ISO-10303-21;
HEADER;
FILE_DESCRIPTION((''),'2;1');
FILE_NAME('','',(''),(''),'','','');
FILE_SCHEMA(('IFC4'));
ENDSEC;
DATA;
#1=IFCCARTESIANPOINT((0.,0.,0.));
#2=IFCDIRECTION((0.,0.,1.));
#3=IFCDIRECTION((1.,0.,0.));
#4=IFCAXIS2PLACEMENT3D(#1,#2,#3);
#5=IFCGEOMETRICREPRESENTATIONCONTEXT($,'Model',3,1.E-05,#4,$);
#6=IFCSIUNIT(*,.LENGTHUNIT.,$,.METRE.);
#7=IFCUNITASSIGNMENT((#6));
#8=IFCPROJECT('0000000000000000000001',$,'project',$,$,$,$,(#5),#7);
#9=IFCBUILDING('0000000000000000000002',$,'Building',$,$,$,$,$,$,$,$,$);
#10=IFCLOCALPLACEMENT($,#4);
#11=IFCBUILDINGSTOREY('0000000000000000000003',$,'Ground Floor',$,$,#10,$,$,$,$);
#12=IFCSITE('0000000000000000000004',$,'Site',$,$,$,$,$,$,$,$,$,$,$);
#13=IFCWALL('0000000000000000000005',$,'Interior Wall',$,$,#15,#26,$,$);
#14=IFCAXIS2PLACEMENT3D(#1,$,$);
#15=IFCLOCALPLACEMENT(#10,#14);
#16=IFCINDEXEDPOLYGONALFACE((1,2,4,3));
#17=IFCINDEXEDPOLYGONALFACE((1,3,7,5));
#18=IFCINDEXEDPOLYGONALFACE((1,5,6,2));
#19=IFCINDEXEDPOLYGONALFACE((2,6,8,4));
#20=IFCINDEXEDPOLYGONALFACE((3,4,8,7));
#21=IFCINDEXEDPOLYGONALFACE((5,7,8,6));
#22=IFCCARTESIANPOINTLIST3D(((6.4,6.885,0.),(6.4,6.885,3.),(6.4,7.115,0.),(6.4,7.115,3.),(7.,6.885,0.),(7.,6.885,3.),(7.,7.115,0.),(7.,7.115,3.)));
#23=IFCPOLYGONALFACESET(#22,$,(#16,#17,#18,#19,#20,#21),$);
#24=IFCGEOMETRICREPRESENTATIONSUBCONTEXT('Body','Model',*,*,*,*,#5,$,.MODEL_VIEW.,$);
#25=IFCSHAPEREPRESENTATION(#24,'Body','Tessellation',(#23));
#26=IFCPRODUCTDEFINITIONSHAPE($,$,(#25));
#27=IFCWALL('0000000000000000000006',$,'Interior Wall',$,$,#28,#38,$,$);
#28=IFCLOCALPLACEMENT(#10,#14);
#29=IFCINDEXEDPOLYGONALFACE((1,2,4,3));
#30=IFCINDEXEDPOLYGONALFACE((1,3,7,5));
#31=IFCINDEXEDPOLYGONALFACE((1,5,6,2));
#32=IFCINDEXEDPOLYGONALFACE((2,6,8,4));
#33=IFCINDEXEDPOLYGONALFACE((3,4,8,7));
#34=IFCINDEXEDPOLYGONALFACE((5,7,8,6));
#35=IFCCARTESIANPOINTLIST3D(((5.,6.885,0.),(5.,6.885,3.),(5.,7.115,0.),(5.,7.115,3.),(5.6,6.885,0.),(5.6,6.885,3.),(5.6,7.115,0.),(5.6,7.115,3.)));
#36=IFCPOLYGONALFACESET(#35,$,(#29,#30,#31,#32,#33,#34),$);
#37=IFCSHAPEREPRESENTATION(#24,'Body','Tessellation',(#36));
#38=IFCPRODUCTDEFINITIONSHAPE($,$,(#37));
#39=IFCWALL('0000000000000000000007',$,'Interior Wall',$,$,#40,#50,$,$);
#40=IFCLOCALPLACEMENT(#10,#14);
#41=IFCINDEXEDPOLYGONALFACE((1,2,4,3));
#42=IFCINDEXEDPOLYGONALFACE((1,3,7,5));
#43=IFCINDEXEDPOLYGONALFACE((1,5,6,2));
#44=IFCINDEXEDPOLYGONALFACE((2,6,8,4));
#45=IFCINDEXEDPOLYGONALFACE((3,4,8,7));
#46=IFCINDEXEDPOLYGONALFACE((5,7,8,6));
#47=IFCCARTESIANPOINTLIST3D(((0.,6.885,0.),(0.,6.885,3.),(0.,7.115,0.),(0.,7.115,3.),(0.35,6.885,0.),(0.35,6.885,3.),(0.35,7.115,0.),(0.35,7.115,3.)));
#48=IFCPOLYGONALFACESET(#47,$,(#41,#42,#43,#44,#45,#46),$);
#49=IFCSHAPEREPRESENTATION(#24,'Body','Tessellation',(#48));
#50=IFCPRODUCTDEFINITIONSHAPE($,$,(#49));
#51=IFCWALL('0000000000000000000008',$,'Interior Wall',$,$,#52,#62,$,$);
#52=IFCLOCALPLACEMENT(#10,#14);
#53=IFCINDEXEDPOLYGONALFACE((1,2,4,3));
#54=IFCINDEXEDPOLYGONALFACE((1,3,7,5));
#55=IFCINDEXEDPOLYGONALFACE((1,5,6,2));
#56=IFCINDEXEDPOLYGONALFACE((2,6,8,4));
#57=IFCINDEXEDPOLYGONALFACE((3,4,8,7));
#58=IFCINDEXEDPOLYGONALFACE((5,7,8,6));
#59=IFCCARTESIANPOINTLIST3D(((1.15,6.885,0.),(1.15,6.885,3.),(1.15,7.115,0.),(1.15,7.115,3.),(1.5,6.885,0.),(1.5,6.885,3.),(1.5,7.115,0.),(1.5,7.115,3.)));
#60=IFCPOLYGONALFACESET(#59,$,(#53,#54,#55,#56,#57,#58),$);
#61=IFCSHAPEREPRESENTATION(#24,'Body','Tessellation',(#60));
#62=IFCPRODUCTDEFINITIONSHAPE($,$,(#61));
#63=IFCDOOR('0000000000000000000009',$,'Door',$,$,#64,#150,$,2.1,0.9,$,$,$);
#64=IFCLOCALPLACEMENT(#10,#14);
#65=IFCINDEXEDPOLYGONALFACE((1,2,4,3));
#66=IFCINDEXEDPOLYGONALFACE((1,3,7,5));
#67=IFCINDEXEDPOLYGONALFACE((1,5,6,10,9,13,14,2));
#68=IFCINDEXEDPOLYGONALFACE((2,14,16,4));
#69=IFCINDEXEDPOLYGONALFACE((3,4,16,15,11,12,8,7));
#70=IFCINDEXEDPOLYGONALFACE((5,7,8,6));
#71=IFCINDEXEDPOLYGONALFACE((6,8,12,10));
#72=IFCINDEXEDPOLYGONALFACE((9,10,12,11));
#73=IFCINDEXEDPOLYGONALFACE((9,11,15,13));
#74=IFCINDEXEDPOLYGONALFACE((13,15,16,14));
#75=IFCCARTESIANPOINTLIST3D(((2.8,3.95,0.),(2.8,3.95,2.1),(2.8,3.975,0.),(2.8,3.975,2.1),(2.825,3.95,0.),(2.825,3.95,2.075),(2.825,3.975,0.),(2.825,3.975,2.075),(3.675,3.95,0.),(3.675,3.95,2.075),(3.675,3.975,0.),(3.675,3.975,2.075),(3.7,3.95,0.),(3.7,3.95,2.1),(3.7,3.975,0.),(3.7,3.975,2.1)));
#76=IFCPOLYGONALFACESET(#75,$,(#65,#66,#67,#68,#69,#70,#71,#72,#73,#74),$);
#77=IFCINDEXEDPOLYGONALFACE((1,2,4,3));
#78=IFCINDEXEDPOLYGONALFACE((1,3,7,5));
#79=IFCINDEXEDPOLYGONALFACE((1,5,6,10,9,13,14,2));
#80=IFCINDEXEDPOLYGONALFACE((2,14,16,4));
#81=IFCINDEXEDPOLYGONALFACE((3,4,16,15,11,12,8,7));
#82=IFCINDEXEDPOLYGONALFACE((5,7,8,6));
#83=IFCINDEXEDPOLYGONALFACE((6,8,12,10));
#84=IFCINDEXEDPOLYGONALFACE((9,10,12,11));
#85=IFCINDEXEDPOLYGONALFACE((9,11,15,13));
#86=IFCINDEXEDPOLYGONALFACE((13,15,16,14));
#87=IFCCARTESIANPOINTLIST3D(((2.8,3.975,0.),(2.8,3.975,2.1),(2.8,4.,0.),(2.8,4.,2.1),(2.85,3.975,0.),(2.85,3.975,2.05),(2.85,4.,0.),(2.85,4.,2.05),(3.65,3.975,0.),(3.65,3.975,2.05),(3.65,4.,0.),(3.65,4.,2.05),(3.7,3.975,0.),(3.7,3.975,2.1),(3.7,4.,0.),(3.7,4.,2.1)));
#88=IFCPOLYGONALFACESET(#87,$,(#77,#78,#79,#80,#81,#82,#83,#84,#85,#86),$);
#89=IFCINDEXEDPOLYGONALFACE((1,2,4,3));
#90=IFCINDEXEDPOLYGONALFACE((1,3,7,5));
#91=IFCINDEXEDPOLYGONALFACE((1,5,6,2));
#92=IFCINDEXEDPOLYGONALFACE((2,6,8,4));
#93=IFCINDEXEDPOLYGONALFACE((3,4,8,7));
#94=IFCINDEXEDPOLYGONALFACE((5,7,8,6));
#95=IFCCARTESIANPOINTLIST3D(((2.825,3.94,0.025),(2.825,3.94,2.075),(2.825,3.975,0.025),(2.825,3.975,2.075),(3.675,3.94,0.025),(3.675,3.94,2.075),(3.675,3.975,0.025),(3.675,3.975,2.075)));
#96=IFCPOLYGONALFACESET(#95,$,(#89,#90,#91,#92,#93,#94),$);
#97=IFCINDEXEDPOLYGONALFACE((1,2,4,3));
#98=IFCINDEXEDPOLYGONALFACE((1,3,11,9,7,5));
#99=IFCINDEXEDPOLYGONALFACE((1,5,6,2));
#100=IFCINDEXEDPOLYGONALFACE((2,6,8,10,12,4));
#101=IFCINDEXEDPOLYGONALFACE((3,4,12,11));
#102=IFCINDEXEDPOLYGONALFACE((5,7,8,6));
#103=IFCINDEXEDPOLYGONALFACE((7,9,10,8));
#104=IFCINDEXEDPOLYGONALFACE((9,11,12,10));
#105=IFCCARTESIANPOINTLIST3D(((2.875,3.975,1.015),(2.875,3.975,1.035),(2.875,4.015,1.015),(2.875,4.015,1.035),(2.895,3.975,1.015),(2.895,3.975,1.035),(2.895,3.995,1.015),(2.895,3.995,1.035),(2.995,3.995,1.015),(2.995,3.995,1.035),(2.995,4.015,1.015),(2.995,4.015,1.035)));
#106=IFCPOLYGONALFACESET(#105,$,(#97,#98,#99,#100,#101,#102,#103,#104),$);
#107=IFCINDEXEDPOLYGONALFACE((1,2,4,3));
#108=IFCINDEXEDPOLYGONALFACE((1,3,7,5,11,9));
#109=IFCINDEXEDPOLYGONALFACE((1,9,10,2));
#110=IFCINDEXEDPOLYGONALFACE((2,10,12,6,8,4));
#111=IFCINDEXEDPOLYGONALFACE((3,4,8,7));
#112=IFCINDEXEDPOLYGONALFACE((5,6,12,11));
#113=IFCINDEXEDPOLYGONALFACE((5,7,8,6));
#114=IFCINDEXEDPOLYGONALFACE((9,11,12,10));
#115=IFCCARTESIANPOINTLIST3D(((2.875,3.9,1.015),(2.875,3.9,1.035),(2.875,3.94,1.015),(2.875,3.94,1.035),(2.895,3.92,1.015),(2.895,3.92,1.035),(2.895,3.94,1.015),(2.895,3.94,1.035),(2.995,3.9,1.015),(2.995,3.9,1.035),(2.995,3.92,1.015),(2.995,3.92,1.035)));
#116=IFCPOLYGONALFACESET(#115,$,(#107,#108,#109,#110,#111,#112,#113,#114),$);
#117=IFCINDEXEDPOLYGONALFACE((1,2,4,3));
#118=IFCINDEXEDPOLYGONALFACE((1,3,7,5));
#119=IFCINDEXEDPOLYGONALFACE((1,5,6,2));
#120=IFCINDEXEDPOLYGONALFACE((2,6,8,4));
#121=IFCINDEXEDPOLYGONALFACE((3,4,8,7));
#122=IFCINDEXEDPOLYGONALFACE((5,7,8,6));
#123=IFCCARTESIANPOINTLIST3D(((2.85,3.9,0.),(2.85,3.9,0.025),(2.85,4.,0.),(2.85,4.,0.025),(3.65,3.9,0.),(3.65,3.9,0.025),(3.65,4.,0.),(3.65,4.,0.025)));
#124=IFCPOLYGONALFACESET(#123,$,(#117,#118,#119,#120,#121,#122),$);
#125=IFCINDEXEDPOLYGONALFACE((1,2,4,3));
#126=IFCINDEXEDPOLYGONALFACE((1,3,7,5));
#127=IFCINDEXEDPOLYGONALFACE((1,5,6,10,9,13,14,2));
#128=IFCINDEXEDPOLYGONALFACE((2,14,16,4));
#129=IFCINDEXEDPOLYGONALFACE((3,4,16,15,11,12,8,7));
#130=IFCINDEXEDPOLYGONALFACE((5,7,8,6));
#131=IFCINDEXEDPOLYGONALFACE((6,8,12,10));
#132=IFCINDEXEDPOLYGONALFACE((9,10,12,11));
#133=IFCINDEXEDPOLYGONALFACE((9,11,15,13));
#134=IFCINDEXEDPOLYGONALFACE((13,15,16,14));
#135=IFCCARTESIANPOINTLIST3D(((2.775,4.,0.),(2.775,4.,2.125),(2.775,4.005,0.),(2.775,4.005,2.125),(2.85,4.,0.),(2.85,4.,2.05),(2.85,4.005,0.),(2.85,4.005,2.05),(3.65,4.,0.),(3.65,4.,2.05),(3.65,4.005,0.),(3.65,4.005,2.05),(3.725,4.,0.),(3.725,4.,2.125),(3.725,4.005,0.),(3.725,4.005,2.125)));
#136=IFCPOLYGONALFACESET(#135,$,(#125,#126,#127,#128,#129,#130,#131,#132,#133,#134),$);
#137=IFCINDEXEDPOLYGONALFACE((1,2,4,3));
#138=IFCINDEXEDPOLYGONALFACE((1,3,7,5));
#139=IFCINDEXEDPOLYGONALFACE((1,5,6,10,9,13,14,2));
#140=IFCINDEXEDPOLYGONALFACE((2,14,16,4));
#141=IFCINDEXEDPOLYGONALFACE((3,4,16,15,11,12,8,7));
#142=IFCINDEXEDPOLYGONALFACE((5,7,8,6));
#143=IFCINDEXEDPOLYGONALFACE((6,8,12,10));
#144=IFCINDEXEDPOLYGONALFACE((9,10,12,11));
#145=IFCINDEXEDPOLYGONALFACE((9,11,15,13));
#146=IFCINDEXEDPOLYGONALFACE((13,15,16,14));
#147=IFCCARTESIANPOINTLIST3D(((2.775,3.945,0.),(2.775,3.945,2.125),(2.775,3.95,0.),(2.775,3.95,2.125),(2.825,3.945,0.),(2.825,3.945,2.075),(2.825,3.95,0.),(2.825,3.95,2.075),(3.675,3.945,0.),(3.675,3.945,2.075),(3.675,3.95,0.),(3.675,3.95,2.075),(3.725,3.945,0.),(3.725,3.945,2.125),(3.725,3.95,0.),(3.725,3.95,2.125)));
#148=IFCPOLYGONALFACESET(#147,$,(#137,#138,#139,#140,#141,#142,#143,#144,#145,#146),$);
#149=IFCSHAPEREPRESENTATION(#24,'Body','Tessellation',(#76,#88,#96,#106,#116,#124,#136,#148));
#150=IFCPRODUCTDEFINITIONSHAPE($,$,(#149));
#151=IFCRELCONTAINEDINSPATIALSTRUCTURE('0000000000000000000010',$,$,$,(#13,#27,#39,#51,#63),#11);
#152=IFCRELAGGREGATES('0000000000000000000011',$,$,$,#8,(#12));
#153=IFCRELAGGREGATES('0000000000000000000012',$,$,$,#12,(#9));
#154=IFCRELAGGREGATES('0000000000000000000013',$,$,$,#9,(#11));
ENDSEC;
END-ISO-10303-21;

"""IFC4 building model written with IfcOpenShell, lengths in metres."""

from ifc_helpers import new_model, si_unit, frame, origin_with_axes, place, context, subcontext, project, spatial, line, indexed_curve, outline, extrude, element, save


model = new_model("IFC4")

# Units and contexts
model_context = context("Model", 3, precision=1e-05, world=origin_with_axes())
body_context = subcontext(model_context, "Body", "Model", "MODEL_VIEW")
ifc_project = project(units=[si_unit("LENGTHUNIT", "METRE")], contexts=[model_context])

# Site, building, storey
site = spatial("IfcSite", under=ifc_project, Name="Site")
building = spatial("IfcBuilding", under=site, Name="Building")
storey_placement = place(None, origin_with_axes())
storey = spatial("IfcBuildingStorey", under=building, at=storey_placement, Name="Ground Floor")

# Walls
for number, where, z_axis, x_axis, name in (
    (1, (7.0, 7.0, 0.0), (0.0, 0.0, 1.0), (-1.0, 0.0, 0.0), "Interior Wall"),
    (2, (5.6, 7.0, 0.0), (0.0, 0.0, 1.0), (-1.0, 0.0, 0.0), "Interior Wall"),
):
    element("IfcWall", number, at=place(storey_placement, frame(where, z_axis=z_axis, x_axis=x_axis)), inside=storey, Name=name, context=body_context, shape_type="SweptSolid", body=[
        extrude(outline(indexed_curve([(0.0, 0.0), (0.0, 0.23), (0.6, 0.23), (0.6, 0.0), (0.0, 0.0)], self_intersect=False)), frame((0.0, -0.115, 0.0), z_axis=(0.0, 0.0, 1.0), x_axis=(1.0, 0.0, 0.0)), (0.0, 0.0, 1.0), 3.0),
    ])
wall_1_placement = place(storey_placement, frame((0.0, 7.0, 0.0), z_axis=(0.0, 0.0, 1.0), x_axis=(1.0, 0.0, 0.0)))
element("IfcWall", 3, at=wall_1_placement, inside=storey, Name="Interior Wall", context=body_context, shape_type="SweptSolid", body=[
    extrude(outline(indexed_curve([(0.0, 0.0), (0.0, 0.23), (0.35, 0.23), (0.35, 0.0), (0.0, 0.0)], self_intersect=False)), frame((0.0, -0.115, 0.0), z_axis=(0.0, 0.0, 1.0), x_axis=(1.0, 0.0, 0.0)), (0.0, 0.0, 1.0), 3.0),
])
wall_2_placement = place(storey_placement, frame((1.15, 7.0, 0.0), z_axis=(0.0, 0.0, 1.0), x_axis=(1.0, 0.0, 0.0)))
element("IfcWall", 4, at=wall_2_placement, inside=storey, Name="Interior Wall", context=body_context, shape_type="SweptSolid", body=[
    extrude(outline(indexed_curve([(0.0, 0.0), (0.0, 0.23), (0.35, 0.23), (0.35, 0.0), (0.0, 0.0)], self_intersect=False)), frame((0.0, -0.115, 0.0), z_axis=(0.0, 0.0, 1.0), x_axis=(1.0, 0.0, 0.0)), (0.0, 0.0, 1.0), 3.0),
])

# Door
door_1_placement = place(storey_placement, frame((3.7, 4.0, 0.0), z_axis=(0.0, 0.0, 1.0), x_axis=(-1.0, 0.0, 0.0)))
element("IfcDoor", 5, at=door_1_placement, inside=storey, Name="Door", OverallHeight=2.1, OverallWidth=0.9, context=body_context, shape_type="SweptSolid", body=[
    extrude(outline(indexed_curve([(0.0, 0.0), (0.0, 2.1), (0.9, 2.1), (0.9, 0.0), (0.875, 0.0), (0.875, 2.075), (0.025, 2.075), (0.025, 0.0)], segments=[line(1, 2, 3, 4, 5, 6, 7, 8, 1)])), frame((0.0, 0.025, 0.0), z_axis=(0.0, -1.0, 0.0), x_axis=(1.0, 0.0, 0.0)), (0.0, 0.0, -1.0), 0.025),
    extrude(outline(indexed_curve([(0.0, 0.0), (0.0, 2.1), (0.9, 2.1), (0.9, 0.0), (0.85, 0.0), (0.85, 2.05), (0.05, 2.05), (0.05, 0.0)], segments=[line(1, 2, 3, 4, 5, 6, 7, 8, 1)])), frame((0.0, 0.0, 0.0), z_axis=(0.0, -1.0, 0.0), x_axis=(1.0, 0.0, 0.0)), (0.0, 0.0, -1.0), 0.025),
    extrude(outline(indexed_curve([(0.0, 0.0), (0.85, 0.0), (0.85, 0.035), (0.0, 0.035)], segments=[line(1, 2, 3, 4, 1)])), frame((0.025, 0.025, 0.025), z_axis=(0.0, 0.0, 1.0), x_axis=(1.0, 0.0, 0.0)), (0.0, 0.0, 1.0), 2.05),
    extrude(outline(indexed_curve([(0.0, 0.0), (0.0, -0.04), (-0.12, -0.04), (-0.12, -0.02), (-0.02, -0.02), (-0.02, 0.0)], segments=[line(1, 2, 3, 4, 5, 6, 1)])), frame((0.825, 0.025, 1.015), z_axis=(0.0, 0.0, 1.0), x_axis=(1.0, 0.0, 0.0)), (0.0, 0.0, 1.0), 0.02),
    extrude(outline(indexed_curve([(0.0, 0.0), (0.0, 0.04), (-0.12, 0.04), (-0.12, 0.02), (-0.02, 0.02), (-0.02, 0.0)], segments=[line(1, 2, 3, 4, 5, 6, 1)])), frame((0.825, 0.06, 1.015), z_axis=(0.0, 0.0, 1.0), x_axis=(1.0, 0.0, 0.0)), (0.0, 0.0, 1.0), 0.02),
    extrude(outline(indexed_curve([(0.0, 0.0), (0.8, 0.0), (0.8, 0.1), (0.0, 0.1)], segments=[line(1, 2, 3, 4, 1)])), frame((0.05, 0.0, 0.0), z_axis=(0.0, 0.0, 1.0), x_axis=(1.0, 0.0, 0.0)), (0.0, 0.0, 1.0), 0.025),
    extrude(outline(indexed_curve([(0.0, 0.0), (0.0, 2.125), (0.95, 2.125), (0.95, 0.0), (0.875, 0.0), (0.875, 2.05), (0.075, 2.05), (0.075, 0.0)], segments=[line(1, 2, 3, 4, 5, 6, 7, 8, 1)])), frame((-0.025, -0.005, 0.0), z_axis=(0.0, -1.0, 0.0), x_axis=(1.0, 0.0, 0.0)), (0.0, 0.0, -1.0), 0.005),
    extrude(outline(indexed_curve([(0.0, 0.0), (0.0, 2.125), (0.95, 2.125), (0.95, 0.0), (0.9, 0.0), (0.9, 2.075), (0.05, 2.075), (0.05, 0.0)], segments=[line(1, 2, 3, 4, 5, 6, 7, 8, 1)])), frame((-0.025, 0.05, 0.0), z_axis=(0.0, -1.0, 0.0), x_axis=(1.0, 0.0, 0.0)), (0.0, 0.0, -1.0), 0.005),
])

save(model, "model.ifc")
